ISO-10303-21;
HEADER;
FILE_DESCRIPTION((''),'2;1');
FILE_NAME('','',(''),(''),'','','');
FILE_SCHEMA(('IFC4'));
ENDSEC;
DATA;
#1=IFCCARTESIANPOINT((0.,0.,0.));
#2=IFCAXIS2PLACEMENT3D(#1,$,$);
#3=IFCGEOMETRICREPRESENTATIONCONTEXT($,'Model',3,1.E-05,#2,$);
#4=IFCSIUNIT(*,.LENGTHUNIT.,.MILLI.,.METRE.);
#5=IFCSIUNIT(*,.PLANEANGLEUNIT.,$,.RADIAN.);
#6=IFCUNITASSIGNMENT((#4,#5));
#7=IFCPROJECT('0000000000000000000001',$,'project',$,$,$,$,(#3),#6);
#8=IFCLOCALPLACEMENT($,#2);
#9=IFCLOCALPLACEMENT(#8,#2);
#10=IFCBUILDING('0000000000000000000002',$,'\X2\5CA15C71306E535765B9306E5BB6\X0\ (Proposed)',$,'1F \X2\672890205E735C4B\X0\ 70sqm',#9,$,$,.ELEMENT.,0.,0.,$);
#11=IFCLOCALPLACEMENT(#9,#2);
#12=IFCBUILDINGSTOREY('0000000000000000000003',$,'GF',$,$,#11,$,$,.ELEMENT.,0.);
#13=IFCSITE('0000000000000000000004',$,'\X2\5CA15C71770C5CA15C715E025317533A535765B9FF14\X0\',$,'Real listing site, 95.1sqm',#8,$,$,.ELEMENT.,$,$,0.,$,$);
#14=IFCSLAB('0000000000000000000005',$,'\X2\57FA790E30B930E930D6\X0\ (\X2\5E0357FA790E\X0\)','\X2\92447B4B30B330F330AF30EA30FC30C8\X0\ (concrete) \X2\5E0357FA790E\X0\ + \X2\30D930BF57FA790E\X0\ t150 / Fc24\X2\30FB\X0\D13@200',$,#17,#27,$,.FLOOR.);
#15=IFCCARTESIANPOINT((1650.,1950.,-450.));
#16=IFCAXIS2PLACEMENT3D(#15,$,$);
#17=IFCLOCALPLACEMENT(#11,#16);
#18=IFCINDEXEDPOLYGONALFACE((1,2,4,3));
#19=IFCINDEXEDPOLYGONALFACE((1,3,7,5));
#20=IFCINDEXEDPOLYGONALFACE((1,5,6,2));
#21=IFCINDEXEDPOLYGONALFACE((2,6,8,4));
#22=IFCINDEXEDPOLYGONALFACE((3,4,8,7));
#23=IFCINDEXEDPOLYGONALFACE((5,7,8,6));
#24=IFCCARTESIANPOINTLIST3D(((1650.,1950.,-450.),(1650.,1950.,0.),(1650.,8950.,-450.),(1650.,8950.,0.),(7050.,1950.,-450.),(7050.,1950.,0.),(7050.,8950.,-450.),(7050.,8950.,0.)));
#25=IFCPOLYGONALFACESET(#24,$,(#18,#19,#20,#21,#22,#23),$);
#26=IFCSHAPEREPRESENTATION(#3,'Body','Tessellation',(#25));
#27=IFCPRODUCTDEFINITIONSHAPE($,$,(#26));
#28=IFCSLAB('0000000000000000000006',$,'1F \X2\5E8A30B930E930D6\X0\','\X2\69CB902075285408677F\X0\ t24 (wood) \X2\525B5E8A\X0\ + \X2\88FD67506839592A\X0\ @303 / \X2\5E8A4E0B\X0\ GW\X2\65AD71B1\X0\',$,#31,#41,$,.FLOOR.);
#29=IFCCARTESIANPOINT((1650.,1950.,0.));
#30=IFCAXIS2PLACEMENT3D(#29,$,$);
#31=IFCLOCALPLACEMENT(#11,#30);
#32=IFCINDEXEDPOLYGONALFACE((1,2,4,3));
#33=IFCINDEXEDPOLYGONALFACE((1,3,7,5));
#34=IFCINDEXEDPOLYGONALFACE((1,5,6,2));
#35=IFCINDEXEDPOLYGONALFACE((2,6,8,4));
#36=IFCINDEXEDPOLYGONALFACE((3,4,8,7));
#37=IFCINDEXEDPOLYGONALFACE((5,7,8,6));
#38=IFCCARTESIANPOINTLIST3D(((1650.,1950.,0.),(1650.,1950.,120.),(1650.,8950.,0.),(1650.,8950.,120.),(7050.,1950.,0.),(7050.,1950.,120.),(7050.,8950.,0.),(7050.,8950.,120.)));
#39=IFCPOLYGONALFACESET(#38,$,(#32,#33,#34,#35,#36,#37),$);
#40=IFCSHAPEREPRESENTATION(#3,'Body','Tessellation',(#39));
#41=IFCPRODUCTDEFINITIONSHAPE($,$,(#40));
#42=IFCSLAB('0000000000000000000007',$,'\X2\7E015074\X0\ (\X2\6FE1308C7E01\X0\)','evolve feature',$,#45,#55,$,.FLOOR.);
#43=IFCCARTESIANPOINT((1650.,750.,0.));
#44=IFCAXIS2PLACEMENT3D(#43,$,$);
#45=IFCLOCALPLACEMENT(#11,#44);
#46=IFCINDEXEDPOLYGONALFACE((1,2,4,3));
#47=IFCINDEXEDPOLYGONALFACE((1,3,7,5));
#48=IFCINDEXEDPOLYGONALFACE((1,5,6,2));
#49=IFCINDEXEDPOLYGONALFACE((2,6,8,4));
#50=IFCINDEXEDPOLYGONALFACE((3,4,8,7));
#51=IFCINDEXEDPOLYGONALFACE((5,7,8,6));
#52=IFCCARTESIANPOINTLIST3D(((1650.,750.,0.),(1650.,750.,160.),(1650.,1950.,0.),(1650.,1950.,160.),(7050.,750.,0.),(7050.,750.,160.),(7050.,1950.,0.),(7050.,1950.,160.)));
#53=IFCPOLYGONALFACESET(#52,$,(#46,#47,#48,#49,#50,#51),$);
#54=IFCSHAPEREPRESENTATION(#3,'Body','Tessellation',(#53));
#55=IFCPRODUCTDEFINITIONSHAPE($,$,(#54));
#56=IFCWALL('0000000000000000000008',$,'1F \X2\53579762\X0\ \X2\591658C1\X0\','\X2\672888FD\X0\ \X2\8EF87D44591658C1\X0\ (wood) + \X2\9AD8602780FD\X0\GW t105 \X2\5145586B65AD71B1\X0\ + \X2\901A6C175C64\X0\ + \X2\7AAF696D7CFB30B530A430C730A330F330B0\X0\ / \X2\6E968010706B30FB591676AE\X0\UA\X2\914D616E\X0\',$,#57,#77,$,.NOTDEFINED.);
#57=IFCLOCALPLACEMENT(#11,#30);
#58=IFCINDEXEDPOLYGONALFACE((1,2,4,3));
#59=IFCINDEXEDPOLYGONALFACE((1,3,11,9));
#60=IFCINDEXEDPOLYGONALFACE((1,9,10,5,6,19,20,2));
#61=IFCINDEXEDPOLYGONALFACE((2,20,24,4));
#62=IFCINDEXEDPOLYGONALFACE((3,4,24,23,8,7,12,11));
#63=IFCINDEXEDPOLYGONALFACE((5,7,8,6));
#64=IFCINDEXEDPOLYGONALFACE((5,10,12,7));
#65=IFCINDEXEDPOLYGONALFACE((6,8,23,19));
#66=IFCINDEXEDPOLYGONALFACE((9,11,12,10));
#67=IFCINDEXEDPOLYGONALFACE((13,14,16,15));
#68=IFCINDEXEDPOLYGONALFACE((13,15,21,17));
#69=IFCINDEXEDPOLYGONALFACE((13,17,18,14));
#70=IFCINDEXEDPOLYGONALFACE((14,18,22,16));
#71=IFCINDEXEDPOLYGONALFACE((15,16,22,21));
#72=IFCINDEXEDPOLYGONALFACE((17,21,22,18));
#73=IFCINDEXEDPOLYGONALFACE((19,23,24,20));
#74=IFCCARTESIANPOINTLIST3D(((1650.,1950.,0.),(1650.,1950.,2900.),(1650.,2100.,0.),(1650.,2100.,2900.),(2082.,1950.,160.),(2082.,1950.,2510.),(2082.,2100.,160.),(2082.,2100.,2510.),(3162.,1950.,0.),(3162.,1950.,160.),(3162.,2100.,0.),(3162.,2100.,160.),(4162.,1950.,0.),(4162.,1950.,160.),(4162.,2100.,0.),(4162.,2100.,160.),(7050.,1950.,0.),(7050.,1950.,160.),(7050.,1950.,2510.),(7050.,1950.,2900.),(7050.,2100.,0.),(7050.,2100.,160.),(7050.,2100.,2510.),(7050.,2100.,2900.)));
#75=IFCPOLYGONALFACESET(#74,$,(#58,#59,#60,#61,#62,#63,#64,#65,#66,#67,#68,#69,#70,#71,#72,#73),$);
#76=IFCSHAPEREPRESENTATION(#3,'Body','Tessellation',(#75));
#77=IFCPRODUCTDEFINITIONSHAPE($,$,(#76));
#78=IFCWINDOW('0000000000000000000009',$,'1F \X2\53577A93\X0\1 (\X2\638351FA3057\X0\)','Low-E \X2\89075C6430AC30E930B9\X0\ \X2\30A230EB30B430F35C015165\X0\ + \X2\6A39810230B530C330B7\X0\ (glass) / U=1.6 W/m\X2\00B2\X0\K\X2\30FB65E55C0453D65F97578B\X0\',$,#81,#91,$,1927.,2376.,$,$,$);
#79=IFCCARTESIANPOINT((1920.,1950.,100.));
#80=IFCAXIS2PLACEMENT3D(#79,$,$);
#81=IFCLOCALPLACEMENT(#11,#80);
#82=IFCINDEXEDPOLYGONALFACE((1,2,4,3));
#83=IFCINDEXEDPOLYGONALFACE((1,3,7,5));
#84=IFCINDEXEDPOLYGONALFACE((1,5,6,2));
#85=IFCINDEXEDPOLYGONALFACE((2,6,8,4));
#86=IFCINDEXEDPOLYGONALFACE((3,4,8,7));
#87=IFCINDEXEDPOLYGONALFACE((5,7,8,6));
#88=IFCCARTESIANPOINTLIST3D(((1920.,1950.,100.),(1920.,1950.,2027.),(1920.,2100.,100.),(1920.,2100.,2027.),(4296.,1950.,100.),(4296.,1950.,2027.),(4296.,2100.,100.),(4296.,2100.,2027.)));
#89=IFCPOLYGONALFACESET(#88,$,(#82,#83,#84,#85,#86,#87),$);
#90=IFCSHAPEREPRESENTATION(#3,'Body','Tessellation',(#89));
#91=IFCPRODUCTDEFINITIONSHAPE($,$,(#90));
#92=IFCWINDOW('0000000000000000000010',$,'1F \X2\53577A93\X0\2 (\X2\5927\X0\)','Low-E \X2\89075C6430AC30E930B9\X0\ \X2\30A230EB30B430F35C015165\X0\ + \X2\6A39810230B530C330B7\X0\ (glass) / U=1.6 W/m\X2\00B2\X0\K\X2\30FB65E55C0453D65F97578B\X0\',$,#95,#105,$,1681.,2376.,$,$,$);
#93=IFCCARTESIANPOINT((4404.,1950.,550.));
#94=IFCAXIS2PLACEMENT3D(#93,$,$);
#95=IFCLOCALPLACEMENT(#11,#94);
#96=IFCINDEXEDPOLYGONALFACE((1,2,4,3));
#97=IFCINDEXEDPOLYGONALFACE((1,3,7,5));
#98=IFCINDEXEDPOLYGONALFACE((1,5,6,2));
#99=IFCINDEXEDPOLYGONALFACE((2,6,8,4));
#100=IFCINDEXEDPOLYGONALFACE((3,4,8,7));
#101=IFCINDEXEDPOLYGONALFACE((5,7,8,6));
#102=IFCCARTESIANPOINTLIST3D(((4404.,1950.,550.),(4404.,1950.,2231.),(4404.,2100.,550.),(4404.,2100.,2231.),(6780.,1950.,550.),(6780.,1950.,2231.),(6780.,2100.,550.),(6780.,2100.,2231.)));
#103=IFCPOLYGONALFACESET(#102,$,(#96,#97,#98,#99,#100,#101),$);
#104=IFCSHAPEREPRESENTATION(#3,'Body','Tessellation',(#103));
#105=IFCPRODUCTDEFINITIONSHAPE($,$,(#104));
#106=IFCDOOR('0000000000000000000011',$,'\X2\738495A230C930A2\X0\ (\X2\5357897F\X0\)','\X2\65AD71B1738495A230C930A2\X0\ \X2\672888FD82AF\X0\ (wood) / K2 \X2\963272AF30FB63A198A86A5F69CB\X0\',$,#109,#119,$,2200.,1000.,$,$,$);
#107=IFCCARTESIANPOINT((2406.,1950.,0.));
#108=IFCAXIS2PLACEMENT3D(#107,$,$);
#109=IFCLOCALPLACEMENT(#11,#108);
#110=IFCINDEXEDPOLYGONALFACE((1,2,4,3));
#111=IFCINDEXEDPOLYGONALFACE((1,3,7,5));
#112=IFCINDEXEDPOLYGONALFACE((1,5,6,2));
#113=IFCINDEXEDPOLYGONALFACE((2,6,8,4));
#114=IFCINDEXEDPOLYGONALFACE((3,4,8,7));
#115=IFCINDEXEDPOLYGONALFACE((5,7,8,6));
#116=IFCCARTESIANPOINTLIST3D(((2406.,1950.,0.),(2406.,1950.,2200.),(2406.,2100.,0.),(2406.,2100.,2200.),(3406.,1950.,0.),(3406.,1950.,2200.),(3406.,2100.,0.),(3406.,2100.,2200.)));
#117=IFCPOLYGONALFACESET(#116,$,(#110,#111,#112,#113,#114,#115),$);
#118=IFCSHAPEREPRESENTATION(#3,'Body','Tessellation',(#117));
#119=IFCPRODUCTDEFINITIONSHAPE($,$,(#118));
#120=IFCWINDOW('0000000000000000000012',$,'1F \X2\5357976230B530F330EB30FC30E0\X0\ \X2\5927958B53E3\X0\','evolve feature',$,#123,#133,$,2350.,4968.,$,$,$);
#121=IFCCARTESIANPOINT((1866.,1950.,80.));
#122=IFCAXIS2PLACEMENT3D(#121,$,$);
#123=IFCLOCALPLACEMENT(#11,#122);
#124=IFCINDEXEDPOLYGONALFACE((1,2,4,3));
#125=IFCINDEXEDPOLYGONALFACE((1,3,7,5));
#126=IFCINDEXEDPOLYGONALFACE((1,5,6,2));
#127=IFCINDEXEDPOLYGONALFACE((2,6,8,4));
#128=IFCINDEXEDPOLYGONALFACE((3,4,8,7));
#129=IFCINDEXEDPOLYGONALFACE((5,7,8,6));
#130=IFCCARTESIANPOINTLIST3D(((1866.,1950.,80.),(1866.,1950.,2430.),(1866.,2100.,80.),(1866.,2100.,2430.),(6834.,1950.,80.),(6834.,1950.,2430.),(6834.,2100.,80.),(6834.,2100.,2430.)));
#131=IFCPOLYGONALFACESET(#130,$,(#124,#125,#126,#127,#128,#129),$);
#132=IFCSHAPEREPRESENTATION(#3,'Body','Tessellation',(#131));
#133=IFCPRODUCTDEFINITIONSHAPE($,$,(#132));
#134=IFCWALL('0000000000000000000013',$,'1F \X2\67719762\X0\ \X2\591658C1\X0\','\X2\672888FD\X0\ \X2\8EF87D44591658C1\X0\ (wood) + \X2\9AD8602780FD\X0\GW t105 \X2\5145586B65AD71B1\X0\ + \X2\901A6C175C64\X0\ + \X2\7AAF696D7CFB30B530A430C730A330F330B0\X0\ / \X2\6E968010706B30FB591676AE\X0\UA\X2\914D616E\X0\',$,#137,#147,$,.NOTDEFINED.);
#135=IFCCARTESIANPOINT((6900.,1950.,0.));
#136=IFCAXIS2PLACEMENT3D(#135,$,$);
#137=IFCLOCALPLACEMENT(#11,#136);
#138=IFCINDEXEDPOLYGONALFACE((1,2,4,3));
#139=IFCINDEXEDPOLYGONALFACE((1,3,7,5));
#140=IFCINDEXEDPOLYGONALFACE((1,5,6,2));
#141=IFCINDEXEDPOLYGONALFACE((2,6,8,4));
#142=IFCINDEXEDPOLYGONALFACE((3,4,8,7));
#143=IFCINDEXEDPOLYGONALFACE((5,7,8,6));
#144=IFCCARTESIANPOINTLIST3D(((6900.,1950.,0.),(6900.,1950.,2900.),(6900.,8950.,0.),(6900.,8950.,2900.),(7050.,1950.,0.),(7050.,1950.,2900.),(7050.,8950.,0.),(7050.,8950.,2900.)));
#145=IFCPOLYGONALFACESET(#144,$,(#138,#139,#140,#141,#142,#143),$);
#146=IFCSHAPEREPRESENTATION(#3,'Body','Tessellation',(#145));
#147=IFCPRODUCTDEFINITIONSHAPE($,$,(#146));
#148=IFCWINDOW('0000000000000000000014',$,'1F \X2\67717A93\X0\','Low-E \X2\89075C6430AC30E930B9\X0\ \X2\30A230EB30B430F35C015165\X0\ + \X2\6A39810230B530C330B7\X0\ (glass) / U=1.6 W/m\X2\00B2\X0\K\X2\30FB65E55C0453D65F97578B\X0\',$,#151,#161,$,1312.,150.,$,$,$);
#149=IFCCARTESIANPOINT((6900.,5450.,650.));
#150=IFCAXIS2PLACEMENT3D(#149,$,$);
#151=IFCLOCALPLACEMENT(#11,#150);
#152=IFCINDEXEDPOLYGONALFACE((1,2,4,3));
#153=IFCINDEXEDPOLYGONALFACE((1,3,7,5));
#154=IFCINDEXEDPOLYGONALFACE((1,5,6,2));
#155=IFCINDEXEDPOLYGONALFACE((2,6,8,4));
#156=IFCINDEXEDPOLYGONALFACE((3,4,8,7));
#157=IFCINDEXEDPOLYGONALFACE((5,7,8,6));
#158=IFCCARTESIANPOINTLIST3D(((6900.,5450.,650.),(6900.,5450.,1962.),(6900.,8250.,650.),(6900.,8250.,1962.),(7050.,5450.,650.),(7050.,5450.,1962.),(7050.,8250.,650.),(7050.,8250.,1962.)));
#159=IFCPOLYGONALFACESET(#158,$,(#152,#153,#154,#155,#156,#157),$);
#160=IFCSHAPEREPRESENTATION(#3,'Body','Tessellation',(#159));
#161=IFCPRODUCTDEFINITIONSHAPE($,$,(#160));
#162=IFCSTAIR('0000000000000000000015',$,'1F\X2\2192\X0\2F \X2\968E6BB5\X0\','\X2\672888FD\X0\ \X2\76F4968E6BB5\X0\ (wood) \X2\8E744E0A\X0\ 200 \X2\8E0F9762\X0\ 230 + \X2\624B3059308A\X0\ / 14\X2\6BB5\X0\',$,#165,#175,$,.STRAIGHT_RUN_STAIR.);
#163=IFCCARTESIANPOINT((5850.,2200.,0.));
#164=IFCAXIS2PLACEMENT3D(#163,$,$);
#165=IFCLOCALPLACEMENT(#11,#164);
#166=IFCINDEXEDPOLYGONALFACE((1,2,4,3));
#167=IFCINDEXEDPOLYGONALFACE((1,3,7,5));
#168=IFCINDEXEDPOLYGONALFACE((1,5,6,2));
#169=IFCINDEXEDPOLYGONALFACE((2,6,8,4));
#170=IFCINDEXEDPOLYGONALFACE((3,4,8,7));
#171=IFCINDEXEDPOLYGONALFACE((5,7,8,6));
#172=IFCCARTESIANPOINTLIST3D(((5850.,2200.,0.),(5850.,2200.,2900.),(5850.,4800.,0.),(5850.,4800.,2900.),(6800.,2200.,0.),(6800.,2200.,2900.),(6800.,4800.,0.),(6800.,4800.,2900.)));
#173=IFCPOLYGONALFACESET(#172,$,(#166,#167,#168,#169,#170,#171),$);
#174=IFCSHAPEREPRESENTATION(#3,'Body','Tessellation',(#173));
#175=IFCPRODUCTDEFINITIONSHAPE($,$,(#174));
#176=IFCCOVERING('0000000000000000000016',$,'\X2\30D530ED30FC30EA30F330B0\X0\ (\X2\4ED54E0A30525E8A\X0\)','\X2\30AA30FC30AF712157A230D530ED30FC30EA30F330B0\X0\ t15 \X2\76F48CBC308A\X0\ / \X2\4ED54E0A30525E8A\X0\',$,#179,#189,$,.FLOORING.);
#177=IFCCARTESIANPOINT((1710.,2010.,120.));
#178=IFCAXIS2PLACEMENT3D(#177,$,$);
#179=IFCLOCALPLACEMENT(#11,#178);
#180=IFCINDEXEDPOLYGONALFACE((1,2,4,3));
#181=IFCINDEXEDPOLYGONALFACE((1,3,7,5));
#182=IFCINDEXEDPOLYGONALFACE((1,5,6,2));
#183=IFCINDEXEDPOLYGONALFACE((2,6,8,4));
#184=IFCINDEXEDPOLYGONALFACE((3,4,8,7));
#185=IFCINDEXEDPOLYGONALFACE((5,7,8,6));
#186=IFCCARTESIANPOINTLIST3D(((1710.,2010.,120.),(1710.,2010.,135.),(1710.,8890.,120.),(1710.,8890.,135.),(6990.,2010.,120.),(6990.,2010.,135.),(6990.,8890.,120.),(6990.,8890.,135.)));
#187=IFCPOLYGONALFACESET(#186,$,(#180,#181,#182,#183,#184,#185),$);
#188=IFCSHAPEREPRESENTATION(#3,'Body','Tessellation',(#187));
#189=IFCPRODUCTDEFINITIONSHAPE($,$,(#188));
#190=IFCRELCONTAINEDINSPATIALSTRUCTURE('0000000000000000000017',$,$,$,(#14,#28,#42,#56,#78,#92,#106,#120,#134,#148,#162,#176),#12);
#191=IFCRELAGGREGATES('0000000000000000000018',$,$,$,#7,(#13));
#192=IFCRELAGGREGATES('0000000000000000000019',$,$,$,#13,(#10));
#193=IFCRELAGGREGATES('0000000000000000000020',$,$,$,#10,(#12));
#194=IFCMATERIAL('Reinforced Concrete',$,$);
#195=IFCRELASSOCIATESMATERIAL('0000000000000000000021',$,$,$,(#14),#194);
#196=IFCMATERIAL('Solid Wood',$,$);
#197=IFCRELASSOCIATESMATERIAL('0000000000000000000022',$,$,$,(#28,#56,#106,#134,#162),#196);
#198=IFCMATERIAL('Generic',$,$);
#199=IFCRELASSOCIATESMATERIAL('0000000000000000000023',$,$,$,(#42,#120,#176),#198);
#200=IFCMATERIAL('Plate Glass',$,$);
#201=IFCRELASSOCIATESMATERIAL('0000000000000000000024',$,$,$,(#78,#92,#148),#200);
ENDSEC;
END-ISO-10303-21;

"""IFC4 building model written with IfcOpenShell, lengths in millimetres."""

from ifc_helpers import new_model, si_unit, frame, frame_2d, origin, place, context, project, spatial, rectangle, extrude, material, element, fill, save


model = new_model("IFC4")

# Units and contexts
model_context = context("Model", 3, precision=1e-05, world=origin())
ifc_project = project(units=[si_unit("LENGTHUNIT", "METRE", prefix="MILLI"), si_unit("PLANEANGLEUNIT", "RADIAN")], contexts=[model_context])

# Site, building, storey
site_placement = place(None, origin())
site = spatial("IfcSite", under=ifc_project, at=site_placement, Name="岡山県岡山市北区南方４", ObjectType="Real listing site, 95.1sqm", CompositionType="ELEMENT", RefElevation=0.0)
building_placement = place(site_placement, origin())
building = spatial("IfcBuilding", under=site, at=building_placement, Name="岡山の南方の家 (Proposed)", ObjectType="1F 木造平屋 70sqm", CompositionType="ELEMENT", ElevationOfRefHeight=0.0, ElevationOfTerrain=0.0)
storey_placement = place(building_placement, origin())
storey = spatial("IfcBuildingStorey", under=building, at=storey_placement, Name="GF", CompositionType="ELEMENT", Elevation=0.0)

# Slabs
ifc_material_1 = material(Name="Reinforced Concrete")
slab_1_placement = place(storey_placement, frame((1650.0, 1950.0, -450.0)))
element("IfcSlab", 1, at=slab_1_placement, inside=storey, material=ifc_material_1, Name="基礎スラブ (布基礎)", Description="鉄筋コンクリート (concrete) 布基礎 + ベタ基礎 t150 / Fc24・D13@200", PredefinedType="FLOOR", context=model_context, shape_type="SweptSolid", body=[
    extrude(rectangle(XDim=5400.0, YDim=7000.0, at=frame_2d((2700.0, 3500.0))), frame((1650.0, 1950.0, -450.0)), (0.0, 0.0, 1.0), 450.0),
])
ifc_material_2 = material(Name="Solid Wood")
slab_2_placement = place(storey_placement, frame((1650.0, 1950.0, 0.0)))
element("IfcSlab", 2, at=slab_2_placement, inside=storey, material=ifc_material_2, Name="1F 床スラブ", Description="構造用合板 t24 (wood) 剛床 + 製材根太 @303 / 床下 GW断熱", PredefinedType="FLOOR", context=model_context, shape_type="SweptSolid", body=[
    extrude(rectangle(XDim=5400.0, YDim=7000.0, at=frame_2d((2700.0, 3500.0))), frame((1650.0, 1950.0, 0.0)), (0.0, 0.0, 1.0), 120.0),
])
ifc_material_3 = material(Name="Generic")
slab_3_placement = place(storey_placement, frame((1650.0, 750.0, 0.0)))
element("IfcSlab", 3, at=slab_3_placement, inside=storey, material=ifc_material_3, Name="縁側 (濡れ縁)", Description="evolve feature", PredefinedType="FLOOR", context=model_context, shape_type="SweptSolid", body=[
    extrude(rectangle(XDim=5400.0, YDim=1200.0, at=frame_2d((2700.0, 600.0))), frame((1650.0, 750.0, 0.0)), (0.0, 0.0, 1.0), 160.0),
])

# Wall, openings, windows, door
wall_1_placement = place(storey_placement, frame((1650.0, 1950.0, 0.0)))
wall_1 = element("IfcWall", 4, at=wall_1_placement, inside=storey, material=ifc_material_2, Name="1F 南面 外壁", Description="木製 軸組外壁 (wood) + 高性能GW t105 充填断熱 + 通気層 + 窯業系サイディング / 準耐火・外皮UA配慮", PredefinedType="NOTDEFINED", context=model_context, shape_type="SweptSolid", body=[
    extrude(rectangle(XDim=5400.0, YDim=150.0, at=frame_2d((2700.0, 75.0))), frame((1650.0, 1950.0, 0.0)), (0.0, 0.0, 1.0), 2900.0),
])
opening_1_placement = place(storey_placement, frame((1920.0, 1950.0, 100.0)))
opening_1 = element("IfcOpeningElement", 5, at=opening_1_placement, cuts=wall_1, PredefinedType="NOTDEFINED", context=model_context, shape_type="SweptSolid", body=[
    extrude(rectangle(XDim=2376.0, YDim=150.0, at=frame_2d((1188.0, 75.0))), frame((1920.0, 1950.0, 100.0)), (0.0, 0.0, 1.0), 1927.0),
])
opening_2_placement = place(storey_placement, frame((4404.0, 1950.0, 550.0)))
opening_2 = element("IfcOpeningElement", 6, at=opening_2_placement, cuts=wall_1, PredefinedType="NOTDEFINED", context=model_context, shape_type="SweptSolid", body=[
    extrude(rectangle(XDim=2376.0, YDim=150.0, at=frame_2d((1188.0, 75.0))), frame((4404.0, 1950.0, 550.0)), (0.0, 0.0, 1.0), 1681.0),
])
opening_3_placement = place(storey_placement, frame((2406.0, 1950.0, 0.0)))
opening_3 = element("IfcOpeningElement", 7, at=opening_3_placement, cuts=wall_1, PredefinedType="NOTDEFINED", context=model_context, shape_type="SweptSolid", body=[
    extrude(rectangle(XDim=1000.0, YDim=150.0, at=frame_2d((500.0, 75.0))), frame((2406.0, 1950.0, 0.0)), (0.0, 0.0, 1.0), 2200.0),
])
opening_4_placement = place(storey_placement, frame((1866.0, 1950.0, 80.0)))
opening_4 = element("IfcOpeningElement", 8, at=opening_4_placement, cuts=wall_1, PredefinedType="NOTDEFINED", context=model_context, shape_type="SweptSolid", body=[
    extrude(rectangle(XDim=4968.0, YDim=150.0, at=frame_2d((2484.0, 75.0))), frame((1866.0, 1950.0, 80.0)), (0.0, 0.0, 1.0), 2350.0),
])
ifc_material_4 = material(Name="Plate Glass")
window_1_placement = place(storey_placement, frame((1920.0, 1950.0, 100.0)))
window_1 = element("IfcWindow", 9, at=window_1_placement, inside=storey, material=ifc_material_4, Name="1F 南窓1 (掃出し)", Description="Low-E 複層ガラス アルゴン封入 + 樹脂サッシ (glass) / U=1.6 W/m²K・日射取得型", OverallHeight=1927.0, OverallWidth=2376.0, context=model_context, shape_type="SweptSolid", body=[
    extrude(rectangle(XDim=2376.0, YDim=150.0, at=frame_2d((1188.0, 75.0))), frame((1920.0, 1950.0, 100.0)), (0.0, 0.0, 1.0), 1927.0),
])
fill(opening_1, window_1)
window_2_placement = place(storey_placement, frame((4404.0, 1950.0, 550.0)))
window_2 = element("IfcWindow", 10, at=window_2_placement, inside=storey, material=ifc_material_4, Name="1F 南窓2 (大)", Description="Low-E 複層ガラス アルゴン封入 + 樹脂サッシ (glass) / U=1.6 W/m²K・日射取得型", OverallHeight=1681.0, OverallWidth=2376.0, context=model_context, shape_type="SweptSolid", body=[
    extrude(rectangle(XDim=2376.0, YDim=150.0, at=frame_2d((1188.0, 75.0))), frame((4404.0, 1950.0, 550.0)), (0.0, 0.0, 1.0), 1681.0),
])
fill(opening_2, window_2)
door_placement = place(storey_placement, frame((2406.0, 1950.0, 0.0)))
door = element("IfcDoor", 11, at=door_placement, inside=storey, material=ifc_material_2, Name="玄関ドア (南西)", Description="断熱玄関ドア 木製芯 (wood) / K2 防犯・採風機構", OverallHeight=2200.0, OverallWidth=1000.0, context=model_context, shape_type="SweptSolid", body=[
    extrude(rectangle(XDim=1000.0, YDim=150.0, at=frame_2d((500.0, 75.0))), frame((2406.0, 1950.0, 0.0)), (0.0, 0.0, 1.0), 2200.0),
])
fill(opening_3, door)
window_3_placement = place(storey_placement, frame((1866.0, 1950.0, 80.0)))
window_3 = element("IfcWindow", 12, at=window_3_placement, inside=storey, material=ifc_material_3, Name="1F 南面サンルーム 大開口", Description="evolve feature", OverallHeight=2350.0, OverallWidth=4968.0, context=model_context, shape_type="SweptSolid", body=[
    extrude(rectangle(XDim=4968.0, YDim=150.0, at=frame_2d((2484.0, 75.0))), frame((1866.0, 1950.0, 80.0)), (0.0, 0.0, 1.0), 2350.0),
])
fill(opening_4, window_3)

# Wall, opening, window
wall_2_placement = place(storey_placement, frame((6900.0, 1950.0, 0.0)))
wall_2 = element("IfcWall", 13, at=wall_2_placement, inside=storey, material=ifc_material_2, Name="1F 東面 外壁", Description="木製 軸組外壁 (wood) + 高性能GW t105 充填断熱 + 通気層 + 窯業系サイディング / 準耐火・外皮UA配慮", PredefinedType="NOTDEFINED", context=model_context, shape_type="SweptSolid", body=[
    extrude(rectangle(XDim=150.0, YDim=7000.0, at=frame_2d((75.0, 3500.0))), frame((6900.0, 1950.0, 0.0)), (0.0, 0.0, 1.0), 2900.0),
])
opening_5_placement = place(storey_placement, frame((6900.0, 5450.0, 650.0)))
opening_5 = element("IfcOpeningElement", 14, at=opening_5_placement, cuts=wall_2, PredefinedType="NOTDEFINED", context=model_context, shape_type="SweptSolid", body=[
    extrude(rectangle(XDim=150.0, YDim=2800.0, at=frame_2d((75.0, 1400.0))), frame((6900.0, 5450.0, 650.0)), (0.0, 0.0, 1.0), 1312.0),
])
window_4_placement = place(storey_placement, frame((6900.0, 5450.0, 650.0)))
window_4 = element("IfcWindow", 15, at=window_4_placement, inside=storey, material=ifc_material_4, Name="1F 東窓", Description="Low-E 複層ガラス アルゴン封入 + 樹脂サッシ (glass) / U=1.6 W/m²K・日射取得型", OverallHeight=1312.0, OverallWidth=150.0, context=model_context, shape_type="SweptSolid", body=[
    extrude(rectangle(XDim=150.0, YDim=2800.0, at=frame_2d((75.0, 1400.0))), frame((6900.0, 5450.0, 650.0)), (0.0, 0.0, 1.0), 1312.0),
])
fill(opening_5, window_4)

# Stair
stair_placement = place(storey_placement, frame((5850.0, 2200.0, 0.0)))
element("IfcStair", 16, at=stair_placement, inside=storey, material=ifc_material_2, Name="1F→2F 階段", Description="木製 直階段 (wood) 蹴上 200 踏面 230 + 手すり / 14段", PredefinedType="STRAIGHT_RUN_STAIR", context=model_context, shape_type="SweptSolid", body=[
    extrude(rectangle(XDim=950.0, YDim=2600.0, at=frame_2d((475.0, 1300.0))), frame((5850.0, 2200.0, 0.0)), (0.0, 0.0, 1.0), 2900.0),
])

# Covering
covering_placement = place(storey_placement, frame((1710.0, 2010.0, 120.0)))
element("IfcCovering", 17, at=covering_placement, inside=storey, material=ifc_material_3, Name="フローリング (仕上げ床)", Description="オーク無垢フローリング t15 直貼り / 仕上げ床", PredefinedType="FLOORING", context=model_context, shape_type="SweptSolid", body=[
    extrude(rectangle(XDim=5280.0, YDim=6880.0, at=frame_2d((2640.0, 3440.0))), frame((1710.0, 2010.0, 120.0)), (0.0, 0.0, 1.0), 15.0),
])

save(model, "model.ifc")
